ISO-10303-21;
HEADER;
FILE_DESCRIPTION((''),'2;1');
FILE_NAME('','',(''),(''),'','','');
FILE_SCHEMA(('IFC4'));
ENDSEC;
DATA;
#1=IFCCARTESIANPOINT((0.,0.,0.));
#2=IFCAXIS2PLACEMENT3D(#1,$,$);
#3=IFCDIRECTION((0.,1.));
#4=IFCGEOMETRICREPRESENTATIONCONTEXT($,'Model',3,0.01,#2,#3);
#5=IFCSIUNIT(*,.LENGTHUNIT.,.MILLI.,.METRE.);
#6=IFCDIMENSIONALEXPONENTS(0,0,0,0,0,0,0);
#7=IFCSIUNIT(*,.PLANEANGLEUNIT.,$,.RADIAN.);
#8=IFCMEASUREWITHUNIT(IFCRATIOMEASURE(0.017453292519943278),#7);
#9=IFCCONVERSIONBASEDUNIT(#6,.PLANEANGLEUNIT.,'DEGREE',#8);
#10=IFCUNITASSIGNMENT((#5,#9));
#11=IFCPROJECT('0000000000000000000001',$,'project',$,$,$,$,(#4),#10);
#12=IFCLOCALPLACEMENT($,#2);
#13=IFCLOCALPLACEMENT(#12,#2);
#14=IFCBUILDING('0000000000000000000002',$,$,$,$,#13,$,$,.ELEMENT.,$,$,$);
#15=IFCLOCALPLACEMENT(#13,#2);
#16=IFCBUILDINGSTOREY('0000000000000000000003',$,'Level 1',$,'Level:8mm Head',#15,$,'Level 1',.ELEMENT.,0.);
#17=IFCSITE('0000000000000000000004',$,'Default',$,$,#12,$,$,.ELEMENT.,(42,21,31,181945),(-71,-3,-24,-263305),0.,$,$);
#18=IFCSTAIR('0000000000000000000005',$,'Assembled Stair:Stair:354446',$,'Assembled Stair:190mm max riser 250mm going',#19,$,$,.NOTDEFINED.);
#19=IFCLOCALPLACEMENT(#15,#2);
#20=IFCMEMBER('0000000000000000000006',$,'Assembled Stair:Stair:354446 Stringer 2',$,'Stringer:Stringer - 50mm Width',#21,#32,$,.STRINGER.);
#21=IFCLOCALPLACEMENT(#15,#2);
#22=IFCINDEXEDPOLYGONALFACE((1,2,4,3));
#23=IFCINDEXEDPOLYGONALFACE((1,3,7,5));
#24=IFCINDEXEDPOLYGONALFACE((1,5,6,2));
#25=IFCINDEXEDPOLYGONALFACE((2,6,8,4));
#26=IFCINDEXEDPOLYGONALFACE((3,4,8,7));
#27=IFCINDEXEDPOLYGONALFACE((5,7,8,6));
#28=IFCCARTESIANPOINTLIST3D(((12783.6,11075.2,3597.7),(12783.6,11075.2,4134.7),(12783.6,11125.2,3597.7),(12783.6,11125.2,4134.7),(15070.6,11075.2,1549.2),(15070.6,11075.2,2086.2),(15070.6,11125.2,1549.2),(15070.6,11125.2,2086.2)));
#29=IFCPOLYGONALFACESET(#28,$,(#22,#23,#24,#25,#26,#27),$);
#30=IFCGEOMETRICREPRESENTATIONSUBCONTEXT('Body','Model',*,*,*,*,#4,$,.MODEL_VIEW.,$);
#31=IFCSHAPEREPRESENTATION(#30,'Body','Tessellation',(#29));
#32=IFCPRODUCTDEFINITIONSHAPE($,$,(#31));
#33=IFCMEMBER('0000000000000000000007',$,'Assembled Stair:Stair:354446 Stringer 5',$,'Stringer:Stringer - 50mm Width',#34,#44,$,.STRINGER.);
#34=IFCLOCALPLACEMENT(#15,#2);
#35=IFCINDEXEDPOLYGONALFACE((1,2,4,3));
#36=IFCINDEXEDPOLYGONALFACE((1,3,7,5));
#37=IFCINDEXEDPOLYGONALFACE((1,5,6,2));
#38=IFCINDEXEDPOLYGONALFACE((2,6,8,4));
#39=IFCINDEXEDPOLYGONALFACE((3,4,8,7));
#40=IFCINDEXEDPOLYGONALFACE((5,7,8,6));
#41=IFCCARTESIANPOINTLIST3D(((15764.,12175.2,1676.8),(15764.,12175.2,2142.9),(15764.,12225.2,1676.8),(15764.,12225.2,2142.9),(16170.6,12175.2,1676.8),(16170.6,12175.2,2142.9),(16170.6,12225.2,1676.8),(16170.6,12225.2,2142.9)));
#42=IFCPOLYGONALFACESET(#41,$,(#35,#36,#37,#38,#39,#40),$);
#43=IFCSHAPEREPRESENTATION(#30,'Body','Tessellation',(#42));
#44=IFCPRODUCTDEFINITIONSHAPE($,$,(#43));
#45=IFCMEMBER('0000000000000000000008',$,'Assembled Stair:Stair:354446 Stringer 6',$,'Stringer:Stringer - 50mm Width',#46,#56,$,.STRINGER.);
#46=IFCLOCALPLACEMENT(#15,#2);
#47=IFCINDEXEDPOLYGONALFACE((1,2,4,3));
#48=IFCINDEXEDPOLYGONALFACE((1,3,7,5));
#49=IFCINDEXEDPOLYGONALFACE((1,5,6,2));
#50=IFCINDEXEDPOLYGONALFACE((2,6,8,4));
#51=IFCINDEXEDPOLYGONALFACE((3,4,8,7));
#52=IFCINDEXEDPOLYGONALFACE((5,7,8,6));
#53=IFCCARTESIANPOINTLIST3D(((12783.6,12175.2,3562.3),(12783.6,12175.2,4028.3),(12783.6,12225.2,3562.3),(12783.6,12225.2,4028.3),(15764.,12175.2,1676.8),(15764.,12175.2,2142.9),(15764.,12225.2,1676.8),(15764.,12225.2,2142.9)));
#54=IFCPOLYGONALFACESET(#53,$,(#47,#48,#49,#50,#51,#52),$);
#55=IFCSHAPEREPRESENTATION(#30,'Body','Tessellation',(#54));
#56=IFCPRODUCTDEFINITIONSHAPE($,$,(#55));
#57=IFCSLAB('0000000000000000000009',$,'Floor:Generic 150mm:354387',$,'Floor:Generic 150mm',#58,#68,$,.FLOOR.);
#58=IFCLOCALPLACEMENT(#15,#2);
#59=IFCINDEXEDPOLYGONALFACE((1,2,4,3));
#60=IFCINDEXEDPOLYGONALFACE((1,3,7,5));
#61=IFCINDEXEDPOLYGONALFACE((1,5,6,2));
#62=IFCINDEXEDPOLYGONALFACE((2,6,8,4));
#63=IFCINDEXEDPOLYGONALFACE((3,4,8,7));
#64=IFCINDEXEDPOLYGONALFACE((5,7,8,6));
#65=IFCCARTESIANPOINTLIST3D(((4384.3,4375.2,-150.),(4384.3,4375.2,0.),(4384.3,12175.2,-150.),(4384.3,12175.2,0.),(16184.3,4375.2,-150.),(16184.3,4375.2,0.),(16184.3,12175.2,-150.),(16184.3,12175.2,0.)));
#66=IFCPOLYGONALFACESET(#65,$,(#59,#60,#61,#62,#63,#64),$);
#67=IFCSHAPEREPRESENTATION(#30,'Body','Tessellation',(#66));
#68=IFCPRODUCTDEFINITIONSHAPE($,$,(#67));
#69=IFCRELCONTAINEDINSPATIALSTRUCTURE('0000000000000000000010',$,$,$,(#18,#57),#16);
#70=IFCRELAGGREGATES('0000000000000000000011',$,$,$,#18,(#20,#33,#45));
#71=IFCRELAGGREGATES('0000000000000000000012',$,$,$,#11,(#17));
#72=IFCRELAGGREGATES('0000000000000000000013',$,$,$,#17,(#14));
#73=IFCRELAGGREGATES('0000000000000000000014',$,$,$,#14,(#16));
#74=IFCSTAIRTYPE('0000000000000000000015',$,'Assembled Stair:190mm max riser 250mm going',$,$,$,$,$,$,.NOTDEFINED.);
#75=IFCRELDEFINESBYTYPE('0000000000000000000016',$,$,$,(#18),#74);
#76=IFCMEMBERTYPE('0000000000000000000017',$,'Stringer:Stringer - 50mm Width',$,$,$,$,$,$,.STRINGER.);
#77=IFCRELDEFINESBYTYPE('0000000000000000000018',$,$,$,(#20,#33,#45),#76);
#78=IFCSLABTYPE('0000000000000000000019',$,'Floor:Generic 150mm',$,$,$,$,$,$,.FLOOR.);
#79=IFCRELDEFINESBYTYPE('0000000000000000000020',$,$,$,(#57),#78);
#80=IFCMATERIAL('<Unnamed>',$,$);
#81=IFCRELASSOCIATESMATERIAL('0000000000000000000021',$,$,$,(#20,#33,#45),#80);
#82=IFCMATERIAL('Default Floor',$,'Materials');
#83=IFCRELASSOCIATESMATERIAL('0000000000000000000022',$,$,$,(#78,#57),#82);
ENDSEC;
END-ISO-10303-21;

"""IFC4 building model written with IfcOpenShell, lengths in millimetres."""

from ifc_helpers import new_model, entity, si_unit, converted_unit, direction, frame, origin, place, context, subcontext, project, spatial, indexed_curve, outline, extrude, material, type_object, element, aggregate, save


model = new_model("IFC4")

# Units and contexts
model_context = context("Model", 3, precision=0.01, world=origin(), true_north=direction((0.0, 1.0)))
body_context = subcontext(model_context, "Body", "Model", "MODEL_VIEW")
ifc_project = project(units=[si_unit("LENGTHUNIT", "METRE", prefix="MILLI"), converted_unit("PLANEANGLEUNIT", "DEGREE", entity("IfcRatioMeasure", 0.017453292519943278), si_unit("PLANEANGLEUNIT", "RADIAN"), dimensions=[0, 0, 0, 0, 0, 0, 0])], contexts=[model_context])

# Site, building, storey
site_placement = place(None, origin())
site = spatial("IfcSite", under=ifc_project, at=site_placement, Name="Default", CompositionType="ELEMENT", RefLatitude=(42, 21, 31, 181945), RefLongitude=(-71, -3, -24, -263305), RefElevation=0.0)
building_placement = place(site_placement, origin())
building = spatial("IfcBuilding", under=site, at=building_placement, CompositionType="ELEMENT")
storey_placement = place(building_placement, origin())
storey = spatial("IfcBuildingStorey", under=building, at=storey_placement, Name="Level 1", ObjectType="Level:8mm Head", LongName="Level 1", CompositionType="ELEMENT", Elevation=0.0)

# Stair, members
stair_type = type_object("IfcStairType", Name="Assembled Stair:190mm max riser 250mm going", PredefinedType="NOTDEFINED")
stair_placement = place(storey_placement, origin())
stair = element("IfcStair", 1, at=stair_placement, inside=storey, type_object=stair_type, Name="Assembled Stair:Stair:354446", ObjectType="Assembled Stair:190mm max riser 250mm going", PredefinedType="NOTDEFINED")
ifc_material_1 = material(Name="<Unnamed>")
member_type = type_object("IfcMemberType", Name="Stringer:Stringer - 50mm Width", PredefinedType="STRINGER")
member_1_placement = place(stair_placement, origin())
member_1 = element("IfcMember", 2, at=member_1_placement, type_object=member_type, material=ifc_material_1, Name="Assembled Stair:Stair:354446 Stringer 2", ObjectType="Stringer:Stringer - 50mm Width", PredefinedType="STRINGER", context=body_context, shape_type="SweptSolid", body=[
    extrude(outline(indexed_curve([(-1714.3, -200.0), (1356.0, -200.0), (1714.3, 200.0), (-1356.0, 200.0), (-1714.3, -200.0)], self_intersect=False)), frame((13927.1, 11075.2, 2842.0), z_axis=(0.0, 1.0, 0.0), x_axis=(-0.744871, 0.0, 0.667208)), (0.0, 0.0, 1.0), 50.0),
])
member_2_placement = place(stair_placement, origin())
member_2 = element("IfcMember", 3, at=member_2_placement, type_object=member_type, material=ifc_material_1, Name="Assembled Stair:Stair:354446 Stringer 5", ObjectType="Stringer:Stringer - 50mm Width", PredefinedType="STRINGER", context=body_context, shape_type="SweptSolid", body=[
    extrude(outline(indexed_curve([(-203.3, -25.0), (203.3, -25.0), (203.3, 25.0), (-203.3, 25.0), (-203.3, -25.0)], self_intersect=False)), frame((15967.3, 12200.2, 1676.8), z_axis=(0.0, 0.0, 1.0), x_axis=(-1.0, 0.0, 0.0)), (0.0, 0.0, 1.0), 466.1),
])
member_3_placement = place(stair_placement, origin())
member_3 = element("IfcMember", 4, at=member_3_placement, type_object=member_type, material=ifc_material_1, Name="Assembled Stair:Stair:354446 Stringer 6", ObjectType="Stringer:Stringer - 50mm Width", PredefinedType="STRINGER", context=body_context, shape_type="SweptSolid", body=[
    extrude(outline(indexed_curve([(-1887.9, -196.9), (1638.7, -196.9), (1887.9, 196.9), (-1638.7, 196.9), (-1887.9, -196.9)], self_intersect=False)), frame((14273.8, 12175.2, 2852.6), z_axis=(0.0, 1.0, 0.0), x_axis=(-0.845092, 0.0, 0.53462)), (0.0, 0.0, 1.0), 50.0),
])

# Slab
ifc_material_2 = material(Name="Default Floor", Category="Materials")
slab_type = type_object("IfcSlabType", Name="Floor:Generic 150mm", PredefinedType="FLOOR", material=ifc_material_2)
slab_placement = place(storey_placement, origin())
element("IfcSlab", 5, at=slab_placement, inside=storey, type_object=slab_type, material=ifc_material_2, Name="Floor:Generic 150mm:354387", ObjectType="Floor:Generic 150mm", PredefinedType="FLOOR", context=body_context, shape_type="SweptSolid", body=[
    extrude(outline(indexed_curve([(-3900.0, -5900.0), (3900.0, -5900.0), (3900.0, 5900.0), (-3900.0, 5900.0), (-3900.0, -5900.0)], self_intersect=False)), frame((10284.3, 8275.2, 0.0), z_axis=(0.0, 0.0, -1.0), x_axis=(0.0, 1.0, 0.0)), (0.0, 0.0, 1.0), 150.0),
])

aggregate(stair, [member_1, member_2, member_3])

save(model, "model.ifc")
